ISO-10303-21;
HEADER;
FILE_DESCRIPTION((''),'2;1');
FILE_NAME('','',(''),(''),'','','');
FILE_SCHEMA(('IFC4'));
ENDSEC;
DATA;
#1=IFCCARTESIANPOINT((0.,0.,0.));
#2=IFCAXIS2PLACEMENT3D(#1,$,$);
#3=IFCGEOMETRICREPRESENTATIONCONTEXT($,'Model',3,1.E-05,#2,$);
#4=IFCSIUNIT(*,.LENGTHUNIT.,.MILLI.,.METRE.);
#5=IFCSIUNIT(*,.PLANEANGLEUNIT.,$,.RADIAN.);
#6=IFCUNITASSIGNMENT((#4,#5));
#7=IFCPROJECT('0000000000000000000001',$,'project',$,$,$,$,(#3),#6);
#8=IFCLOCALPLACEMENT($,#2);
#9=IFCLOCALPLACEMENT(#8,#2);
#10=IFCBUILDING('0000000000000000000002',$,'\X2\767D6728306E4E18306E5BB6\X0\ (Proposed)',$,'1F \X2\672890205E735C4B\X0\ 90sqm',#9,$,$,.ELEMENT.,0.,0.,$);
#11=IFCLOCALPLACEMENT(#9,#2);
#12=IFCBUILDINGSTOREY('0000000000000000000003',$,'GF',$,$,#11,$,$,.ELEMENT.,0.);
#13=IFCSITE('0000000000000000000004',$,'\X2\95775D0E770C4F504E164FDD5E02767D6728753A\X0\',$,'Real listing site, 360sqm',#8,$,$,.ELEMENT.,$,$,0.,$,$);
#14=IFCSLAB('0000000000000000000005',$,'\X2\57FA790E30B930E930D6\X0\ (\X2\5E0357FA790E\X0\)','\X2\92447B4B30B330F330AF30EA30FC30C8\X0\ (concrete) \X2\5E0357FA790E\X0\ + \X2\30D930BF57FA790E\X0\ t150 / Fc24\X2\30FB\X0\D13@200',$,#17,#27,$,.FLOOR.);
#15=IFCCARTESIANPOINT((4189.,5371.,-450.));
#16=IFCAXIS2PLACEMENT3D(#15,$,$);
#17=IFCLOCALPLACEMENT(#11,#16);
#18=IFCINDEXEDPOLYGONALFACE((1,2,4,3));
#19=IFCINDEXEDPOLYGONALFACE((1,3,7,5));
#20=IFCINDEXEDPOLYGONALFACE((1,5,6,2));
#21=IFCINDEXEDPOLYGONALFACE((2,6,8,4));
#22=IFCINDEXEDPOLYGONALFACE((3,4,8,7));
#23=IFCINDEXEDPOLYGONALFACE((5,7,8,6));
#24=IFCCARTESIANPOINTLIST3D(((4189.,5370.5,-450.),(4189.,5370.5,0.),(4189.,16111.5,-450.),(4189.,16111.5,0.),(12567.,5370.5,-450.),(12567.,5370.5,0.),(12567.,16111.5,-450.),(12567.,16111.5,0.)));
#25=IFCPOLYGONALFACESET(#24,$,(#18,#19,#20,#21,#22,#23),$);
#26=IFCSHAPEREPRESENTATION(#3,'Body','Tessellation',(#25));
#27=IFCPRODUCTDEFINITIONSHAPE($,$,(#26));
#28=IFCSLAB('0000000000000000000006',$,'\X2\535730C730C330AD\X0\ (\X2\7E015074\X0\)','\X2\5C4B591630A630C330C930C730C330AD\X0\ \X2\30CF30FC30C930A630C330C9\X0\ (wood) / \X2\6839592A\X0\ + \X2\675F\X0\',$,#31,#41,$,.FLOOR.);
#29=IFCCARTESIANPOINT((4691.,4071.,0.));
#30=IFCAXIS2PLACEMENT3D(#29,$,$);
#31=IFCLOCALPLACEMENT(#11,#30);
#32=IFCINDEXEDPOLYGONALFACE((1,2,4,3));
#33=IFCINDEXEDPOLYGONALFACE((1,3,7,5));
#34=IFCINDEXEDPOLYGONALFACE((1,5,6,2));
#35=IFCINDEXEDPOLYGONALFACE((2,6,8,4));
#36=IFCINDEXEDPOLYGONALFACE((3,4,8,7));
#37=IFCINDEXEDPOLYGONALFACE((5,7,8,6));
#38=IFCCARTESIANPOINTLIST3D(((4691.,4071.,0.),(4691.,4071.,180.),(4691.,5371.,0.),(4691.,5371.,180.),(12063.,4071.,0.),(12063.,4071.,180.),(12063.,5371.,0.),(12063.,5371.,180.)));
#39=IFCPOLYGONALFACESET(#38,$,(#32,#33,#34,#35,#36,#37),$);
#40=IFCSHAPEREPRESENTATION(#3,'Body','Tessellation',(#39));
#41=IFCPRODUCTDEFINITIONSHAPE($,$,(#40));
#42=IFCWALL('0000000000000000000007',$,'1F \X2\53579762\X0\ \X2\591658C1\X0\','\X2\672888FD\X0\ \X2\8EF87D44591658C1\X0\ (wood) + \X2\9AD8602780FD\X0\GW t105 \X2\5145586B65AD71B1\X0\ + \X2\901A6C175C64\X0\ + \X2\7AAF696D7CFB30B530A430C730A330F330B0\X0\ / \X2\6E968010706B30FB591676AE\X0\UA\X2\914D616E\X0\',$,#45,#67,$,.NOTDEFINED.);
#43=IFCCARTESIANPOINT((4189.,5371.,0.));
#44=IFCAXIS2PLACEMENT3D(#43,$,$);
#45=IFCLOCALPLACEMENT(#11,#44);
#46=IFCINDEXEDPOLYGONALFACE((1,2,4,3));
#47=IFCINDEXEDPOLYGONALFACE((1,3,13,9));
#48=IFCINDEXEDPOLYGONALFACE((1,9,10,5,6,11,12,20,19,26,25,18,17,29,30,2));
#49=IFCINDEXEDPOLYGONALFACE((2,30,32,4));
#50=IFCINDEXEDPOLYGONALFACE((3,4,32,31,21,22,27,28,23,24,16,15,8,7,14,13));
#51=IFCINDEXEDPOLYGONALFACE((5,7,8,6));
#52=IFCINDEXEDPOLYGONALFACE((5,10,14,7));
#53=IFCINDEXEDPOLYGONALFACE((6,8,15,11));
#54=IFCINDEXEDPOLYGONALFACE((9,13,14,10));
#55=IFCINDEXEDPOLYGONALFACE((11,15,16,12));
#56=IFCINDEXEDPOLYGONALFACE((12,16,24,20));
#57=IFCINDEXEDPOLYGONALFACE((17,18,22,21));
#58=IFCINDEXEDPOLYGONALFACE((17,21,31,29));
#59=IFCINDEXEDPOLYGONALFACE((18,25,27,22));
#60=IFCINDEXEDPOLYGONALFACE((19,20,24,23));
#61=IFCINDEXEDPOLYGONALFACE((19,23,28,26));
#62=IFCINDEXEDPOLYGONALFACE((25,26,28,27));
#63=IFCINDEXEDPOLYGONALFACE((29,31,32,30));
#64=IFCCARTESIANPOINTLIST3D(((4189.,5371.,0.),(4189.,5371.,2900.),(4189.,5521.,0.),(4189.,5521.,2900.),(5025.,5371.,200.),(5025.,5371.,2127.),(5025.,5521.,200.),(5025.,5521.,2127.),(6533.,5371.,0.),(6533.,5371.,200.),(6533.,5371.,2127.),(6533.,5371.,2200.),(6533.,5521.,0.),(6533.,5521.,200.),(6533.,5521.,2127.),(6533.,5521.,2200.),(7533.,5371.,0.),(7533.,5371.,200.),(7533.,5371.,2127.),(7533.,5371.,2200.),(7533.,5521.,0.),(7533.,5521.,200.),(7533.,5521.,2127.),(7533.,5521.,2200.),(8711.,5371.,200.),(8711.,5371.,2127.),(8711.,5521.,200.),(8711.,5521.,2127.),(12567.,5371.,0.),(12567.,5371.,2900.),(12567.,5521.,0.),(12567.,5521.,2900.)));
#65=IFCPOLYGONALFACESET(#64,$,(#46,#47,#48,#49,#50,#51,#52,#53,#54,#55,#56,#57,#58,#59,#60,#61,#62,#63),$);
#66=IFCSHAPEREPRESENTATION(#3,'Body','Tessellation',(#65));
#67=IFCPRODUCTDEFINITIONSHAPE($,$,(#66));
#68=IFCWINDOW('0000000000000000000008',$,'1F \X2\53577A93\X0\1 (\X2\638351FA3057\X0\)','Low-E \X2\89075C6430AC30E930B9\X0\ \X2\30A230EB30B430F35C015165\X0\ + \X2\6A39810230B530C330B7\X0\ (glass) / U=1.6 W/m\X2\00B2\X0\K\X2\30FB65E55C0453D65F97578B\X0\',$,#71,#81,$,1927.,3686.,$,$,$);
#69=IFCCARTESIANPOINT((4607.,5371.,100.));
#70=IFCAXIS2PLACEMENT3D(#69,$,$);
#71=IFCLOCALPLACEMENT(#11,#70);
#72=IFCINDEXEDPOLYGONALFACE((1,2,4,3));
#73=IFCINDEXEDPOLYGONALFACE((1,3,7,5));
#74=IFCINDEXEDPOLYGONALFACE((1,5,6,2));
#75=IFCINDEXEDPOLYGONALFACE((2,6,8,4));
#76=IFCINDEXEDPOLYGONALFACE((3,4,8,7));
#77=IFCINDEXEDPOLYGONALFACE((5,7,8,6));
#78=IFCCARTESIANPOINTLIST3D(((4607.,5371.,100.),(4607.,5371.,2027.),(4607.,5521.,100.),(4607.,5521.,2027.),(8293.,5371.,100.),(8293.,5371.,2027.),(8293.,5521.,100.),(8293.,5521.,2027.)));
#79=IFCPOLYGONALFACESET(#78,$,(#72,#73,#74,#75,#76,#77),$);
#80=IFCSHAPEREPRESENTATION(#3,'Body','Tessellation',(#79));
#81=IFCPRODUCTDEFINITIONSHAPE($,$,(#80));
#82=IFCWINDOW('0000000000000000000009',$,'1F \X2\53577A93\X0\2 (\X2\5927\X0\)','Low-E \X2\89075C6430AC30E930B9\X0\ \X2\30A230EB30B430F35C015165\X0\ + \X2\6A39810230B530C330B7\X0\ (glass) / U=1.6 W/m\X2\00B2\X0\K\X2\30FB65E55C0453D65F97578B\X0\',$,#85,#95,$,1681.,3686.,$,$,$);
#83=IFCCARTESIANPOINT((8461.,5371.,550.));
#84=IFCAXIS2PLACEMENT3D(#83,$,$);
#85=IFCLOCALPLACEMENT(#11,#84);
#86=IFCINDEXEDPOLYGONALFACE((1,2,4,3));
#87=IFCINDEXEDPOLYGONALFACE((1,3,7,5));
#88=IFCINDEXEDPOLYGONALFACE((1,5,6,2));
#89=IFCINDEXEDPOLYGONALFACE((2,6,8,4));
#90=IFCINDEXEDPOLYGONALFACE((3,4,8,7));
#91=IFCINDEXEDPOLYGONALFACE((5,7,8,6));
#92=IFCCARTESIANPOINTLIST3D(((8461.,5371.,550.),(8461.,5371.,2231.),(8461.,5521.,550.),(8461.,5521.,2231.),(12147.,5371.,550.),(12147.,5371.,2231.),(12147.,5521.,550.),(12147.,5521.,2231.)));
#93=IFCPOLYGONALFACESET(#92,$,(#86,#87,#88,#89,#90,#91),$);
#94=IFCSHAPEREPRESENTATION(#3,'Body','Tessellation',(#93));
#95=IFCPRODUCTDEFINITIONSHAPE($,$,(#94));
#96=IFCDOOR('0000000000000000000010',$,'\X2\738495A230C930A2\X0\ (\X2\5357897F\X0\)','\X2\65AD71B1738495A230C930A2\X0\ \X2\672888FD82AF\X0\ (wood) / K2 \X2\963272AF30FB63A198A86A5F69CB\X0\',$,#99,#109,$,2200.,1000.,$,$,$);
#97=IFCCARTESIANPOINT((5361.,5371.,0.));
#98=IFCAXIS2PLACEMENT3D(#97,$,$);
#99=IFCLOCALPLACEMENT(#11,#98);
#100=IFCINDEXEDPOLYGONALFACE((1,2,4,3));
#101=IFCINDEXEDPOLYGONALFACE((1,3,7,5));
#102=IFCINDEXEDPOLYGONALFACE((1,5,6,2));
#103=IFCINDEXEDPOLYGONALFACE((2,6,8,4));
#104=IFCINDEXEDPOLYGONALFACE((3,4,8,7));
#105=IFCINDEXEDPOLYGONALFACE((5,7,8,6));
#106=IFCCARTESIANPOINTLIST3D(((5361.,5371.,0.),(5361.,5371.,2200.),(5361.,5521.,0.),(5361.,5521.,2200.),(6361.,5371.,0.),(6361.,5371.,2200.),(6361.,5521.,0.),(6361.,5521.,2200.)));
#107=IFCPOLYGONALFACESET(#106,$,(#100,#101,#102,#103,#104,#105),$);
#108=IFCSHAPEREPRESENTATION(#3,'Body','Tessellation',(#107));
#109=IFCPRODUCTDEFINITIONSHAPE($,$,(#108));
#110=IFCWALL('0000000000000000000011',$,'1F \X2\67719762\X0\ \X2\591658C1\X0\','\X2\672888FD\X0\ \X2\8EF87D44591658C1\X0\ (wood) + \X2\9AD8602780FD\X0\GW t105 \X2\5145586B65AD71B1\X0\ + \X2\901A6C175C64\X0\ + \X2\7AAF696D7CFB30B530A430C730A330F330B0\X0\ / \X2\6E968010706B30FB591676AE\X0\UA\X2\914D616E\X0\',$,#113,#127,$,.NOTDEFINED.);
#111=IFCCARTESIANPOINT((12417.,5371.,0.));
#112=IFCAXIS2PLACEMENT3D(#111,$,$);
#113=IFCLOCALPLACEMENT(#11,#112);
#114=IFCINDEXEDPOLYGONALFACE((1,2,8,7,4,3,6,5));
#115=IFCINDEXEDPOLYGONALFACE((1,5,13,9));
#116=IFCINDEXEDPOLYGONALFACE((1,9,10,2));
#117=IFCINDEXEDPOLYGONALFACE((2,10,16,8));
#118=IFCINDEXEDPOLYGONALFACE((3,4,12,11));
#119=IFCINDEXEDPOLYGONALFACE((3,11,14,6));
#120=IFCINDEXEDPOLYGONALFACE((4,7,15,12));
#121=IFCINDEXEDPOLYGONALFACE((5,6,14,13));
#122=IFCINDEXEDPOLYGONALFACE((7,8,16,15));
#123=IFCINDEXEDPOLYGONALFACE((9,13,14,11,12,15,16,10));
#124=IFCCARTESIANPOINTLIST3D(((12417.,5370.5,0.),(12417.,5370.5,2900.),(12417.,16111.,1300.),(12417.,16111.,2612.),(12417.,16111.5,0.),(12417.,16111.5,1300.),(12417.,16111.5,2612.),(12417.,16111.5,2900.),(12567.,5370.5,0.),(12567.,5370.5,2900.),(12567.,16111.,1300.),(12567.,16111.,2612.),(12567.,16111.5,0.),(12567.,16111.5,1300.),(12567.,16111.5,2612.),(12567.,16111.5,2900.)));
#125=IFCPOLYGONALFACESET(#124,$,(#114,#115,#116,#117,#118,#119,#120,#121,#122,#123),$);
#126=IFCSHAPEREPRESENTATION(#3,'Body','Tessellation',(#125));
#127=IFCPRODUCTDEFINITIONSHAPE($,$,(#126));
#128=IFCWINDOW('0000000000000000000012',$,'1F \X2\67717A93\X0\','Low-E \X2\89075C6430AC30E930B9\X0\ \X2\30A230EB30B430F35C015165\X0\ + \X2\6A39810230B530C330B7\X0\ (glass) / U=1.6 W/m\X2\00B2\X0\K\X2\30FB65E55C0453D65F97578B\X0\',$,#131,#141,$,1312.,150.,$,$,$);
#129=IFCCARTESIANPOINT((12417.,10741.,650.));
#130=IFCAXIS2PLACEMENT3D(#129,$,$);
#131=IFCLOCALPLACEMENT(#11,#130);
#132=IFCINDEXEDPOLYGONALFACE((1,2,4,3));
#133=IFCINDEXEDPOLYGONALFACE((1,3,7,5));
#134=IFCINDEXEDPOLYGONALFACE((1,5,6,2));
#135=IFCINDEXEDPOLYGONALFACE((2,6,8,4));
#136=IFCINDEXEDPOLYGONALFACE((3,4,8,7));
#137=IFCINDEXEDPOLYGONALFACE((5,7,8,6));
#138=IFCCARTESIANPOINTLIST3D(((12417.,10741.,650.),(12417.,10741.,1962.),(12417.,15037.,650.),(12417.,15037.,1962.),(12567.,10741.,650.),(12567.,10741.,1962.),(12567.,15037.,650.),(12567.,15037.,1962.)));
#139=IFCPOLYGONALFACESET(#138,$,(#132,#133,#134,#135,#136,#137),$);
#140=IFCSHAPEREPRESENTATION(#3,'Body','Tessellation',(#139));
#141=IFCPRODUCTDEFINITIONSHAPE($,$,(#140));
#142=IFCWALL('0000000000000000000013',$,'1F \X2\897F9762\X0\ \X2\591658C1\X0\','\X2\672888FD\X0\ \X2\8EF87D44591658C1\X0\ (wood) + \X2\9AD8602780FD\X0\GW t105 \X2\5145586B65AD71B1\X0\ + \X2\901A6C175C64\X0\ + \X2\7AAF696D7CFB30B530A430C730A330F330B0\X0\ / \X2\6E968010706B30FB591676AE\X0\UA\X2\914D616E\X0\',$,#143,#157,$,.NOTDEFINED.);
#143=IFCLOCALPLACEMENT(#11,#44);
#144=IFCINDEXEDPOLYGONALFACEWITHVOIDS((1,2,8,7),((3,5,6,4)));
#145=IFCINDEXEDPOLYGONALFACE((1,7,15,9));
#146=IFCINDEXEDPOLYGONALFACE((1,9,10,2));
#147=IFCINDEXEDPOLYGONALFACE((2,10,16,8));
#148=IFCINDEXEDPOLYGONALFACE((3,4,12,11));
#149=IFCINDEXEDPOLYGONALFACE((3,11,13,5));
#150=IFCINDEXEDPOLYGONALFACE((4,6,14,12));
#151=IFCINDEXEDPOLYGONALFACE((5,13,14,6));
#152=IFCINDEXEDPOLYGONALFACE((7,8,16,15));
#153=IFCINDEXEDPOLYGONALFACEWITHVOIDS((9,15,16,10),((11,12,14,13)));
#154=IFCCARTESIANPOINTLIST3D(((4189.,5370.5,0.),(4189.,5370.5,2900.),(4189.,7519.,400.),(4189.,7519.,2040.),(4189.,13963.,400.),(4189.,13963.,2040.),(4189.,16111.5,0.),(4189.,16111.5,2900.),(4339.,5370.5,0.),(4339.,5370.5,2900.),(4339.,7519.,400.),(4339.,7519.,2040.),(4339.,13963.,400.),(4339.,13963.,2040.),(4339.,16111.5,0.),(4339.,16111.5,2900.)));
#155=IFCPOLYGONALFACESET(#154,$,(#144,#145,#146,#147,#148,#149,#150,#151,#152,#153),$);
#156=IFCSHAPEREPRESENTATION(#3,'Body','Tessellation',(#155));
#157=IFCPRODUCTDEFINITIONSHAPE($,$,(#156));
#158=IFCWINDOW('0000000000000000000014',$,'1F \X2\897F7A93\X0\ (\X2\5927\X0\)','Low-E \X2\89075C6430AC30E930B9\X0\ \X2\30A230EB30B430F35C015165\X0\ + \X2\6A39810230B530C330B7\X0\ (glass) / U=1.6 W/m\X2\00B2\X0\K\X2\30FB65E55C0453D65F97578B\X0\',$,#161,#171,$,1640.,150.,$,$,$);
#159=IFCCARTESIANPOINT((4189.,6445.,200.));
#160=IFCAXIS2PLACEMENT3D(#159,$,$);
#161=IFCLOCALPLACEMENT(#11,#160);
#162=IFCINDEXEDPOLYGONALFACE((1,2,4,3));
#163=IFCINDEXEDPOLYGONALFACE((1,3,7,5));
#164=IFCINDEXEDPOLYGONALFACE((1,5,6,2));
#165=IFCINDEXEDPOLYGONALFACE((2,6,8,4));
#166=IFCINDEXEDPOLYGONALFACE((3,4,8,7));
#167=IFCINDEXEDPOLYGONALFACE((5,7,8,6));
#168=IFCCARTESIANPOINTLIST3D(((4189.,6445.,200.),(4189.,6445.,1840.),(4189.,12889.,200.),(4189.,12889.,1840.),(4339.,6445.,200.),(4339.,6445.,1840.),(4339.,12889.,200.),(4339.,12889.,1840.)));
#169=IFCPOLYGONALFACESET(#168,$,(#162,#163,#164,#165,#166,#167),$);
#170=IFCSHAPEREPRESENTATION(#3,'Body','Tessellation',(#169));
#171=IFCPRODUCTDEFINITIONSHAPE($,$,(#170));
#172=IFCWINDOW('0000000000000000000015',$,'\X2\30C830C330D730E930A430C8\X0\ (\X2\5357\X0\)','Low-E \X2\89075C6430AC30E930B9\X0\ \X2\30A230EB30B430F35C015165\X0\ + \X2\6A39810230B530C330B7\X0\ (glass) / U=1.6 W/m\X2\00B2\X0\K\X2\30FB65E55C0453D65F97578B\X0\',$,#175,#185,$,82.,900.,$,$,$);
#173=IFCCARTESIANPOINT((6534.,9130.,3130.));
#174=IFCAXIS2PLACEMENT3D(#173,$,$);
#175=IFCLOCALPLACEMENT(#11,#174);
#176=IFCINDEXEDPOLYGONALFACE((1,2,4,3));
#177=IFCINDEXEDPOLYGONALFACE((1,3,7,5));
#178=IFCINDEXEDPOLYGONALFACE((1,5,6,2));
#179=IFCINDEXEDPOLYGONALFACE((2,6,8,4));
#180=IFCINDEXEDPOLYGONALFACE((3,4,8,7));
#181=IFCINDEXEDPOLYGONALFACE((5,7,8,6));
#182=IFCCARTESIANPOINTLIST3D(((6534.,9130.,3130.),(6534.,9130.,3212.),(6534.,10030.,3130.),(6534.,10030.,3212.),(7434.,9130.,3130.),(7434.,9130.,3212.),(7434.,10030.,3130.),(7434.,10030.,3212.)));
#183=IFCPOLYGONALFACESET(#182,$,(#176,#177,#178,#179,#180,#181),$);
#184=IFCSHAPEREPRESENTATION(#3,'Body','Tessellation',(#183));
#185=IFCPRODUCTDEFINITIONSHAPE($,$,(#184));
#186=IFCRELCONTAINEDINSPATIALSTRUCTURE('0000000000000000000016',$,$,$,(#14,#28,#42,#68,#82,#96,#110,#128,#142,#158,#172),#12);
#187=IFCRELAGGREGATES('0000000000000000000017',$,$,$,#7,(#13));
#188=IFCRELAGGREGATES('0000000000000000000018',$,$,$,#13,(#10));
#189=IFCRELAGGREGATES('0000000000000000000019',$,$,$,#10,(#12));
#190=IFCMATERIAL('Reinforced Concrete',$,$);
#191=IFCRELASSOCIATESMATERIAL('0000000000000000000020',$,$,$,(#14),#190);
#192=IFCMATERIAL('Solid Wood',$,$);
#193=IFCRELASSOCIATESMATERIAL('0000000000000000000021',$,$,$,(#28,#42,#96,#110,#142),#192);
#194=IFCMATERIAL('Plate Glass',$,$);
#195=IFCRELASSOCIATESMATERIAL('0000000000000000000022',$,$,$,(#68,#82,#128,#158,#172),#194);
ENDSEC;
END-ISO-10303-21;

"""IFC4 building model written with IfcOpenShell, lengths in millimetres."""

from ifc_helpers import new_model, si_unit, frame, frame_2d, origin, place, context, project, spatial, rectangle, extrude, material, element, fill, save


model = new_model("IFC4")

# Units and contexts
model_context = context("Model", 3, precision=1e-05, world=origin())
ifc_project = project(units=[si_unit("LENGTHUNIT", "METRE", prefix="MILLI"), si_unit("PLANEANGLEUNIT", "RADIAN")], contexts=[model_context])

# Site, building, storey
site_placement = place(None, origin())
site = spatial("IfcSite", under=ifc_project, at=site_placement, Name="長崎県佐世保市白木町", ObjectType="Real listing site, 360sqm", CompositionType="ELEMENT", RefElevation=0.0)
building_placement = place(site_placement, origin())
building = spatial("IfcBuilding", under=site, at=building_placement, Name="白木の丘の家 (Proposed)", ObjectType="1F 木造平屋 90sqm", CompositionType="ELEMENT", ElevationOfRefHeight=0.0, ElevationOfTerrain=0.0)
storey_placement = place(building_placement, origin())
storey = spatial("IfcBuildingStorey", under=building, at=storey_placement, Name="GF", CompositionType="ELEMENT", Elevation=0.0)

# Slabs
ifc_material_1 = material(Name="Reinforced Concrete")
slab_1_placement = place(storey_placement, frame((4189.0, 5371.0, -450.0)))
element("IfcSlab", 1, at=slab_1_placement, inside=storey, material=ifc_material_1, Name="基礎スラブ (布基礎)", Description="鉄筋コンクリート (concrete) 布基礎 + ベタ基礎 t150 / Fc24・D13@200", PredefinedType="FLOOR", context=model_context, shape_type="SweptSolid", body=[
    extrude(rectangle(XDim=8378.0, YDim=10741.0, at=frame_2d((4189.0, 5370.0))), frame((4189.0, 5371.0, -450.0)), (0.0, 0.0, 1.0), 450.0),
])
ifc_material_2 = material(Name="Solid Wood")
slab_2_placement = place(storey_placement, frame((4691.0, 4071.0, 0.0)))
element("IfcSlab", 2, at=slab_2_placement, inside=storey, material=ifc_material_2, Name="南デッキ (縁側)", Description="屋外ウッドデッキ ハードウッド (wood) / 根太 + 束", PredefinedType="FLOOR", context=model_context, shape_type="SweptSolid", body=[
    extrude(rectangle(XDim=7372.0, YDim=1300.0, at=frame_2d((3686.0, 650.0))), frame((4691.0, 4071.0, 0.0)), (0.0, 0.0, 1.0), 180.0),
])

# Wall, openings, windows, door
wall_1_placement = place(storey_placement, frame((4189.0, 5371.0, 0.0)))
wall_1 = element("IfcWall", 3, at=wall_1_placement, inside=storey, material=ifc_material_2, Name="1F 南面 外壁", Description="木製 軸組外壁 (wood) + 高性能GW t105 充填断熱 + 通気層 + 窯業系サイディング / 準耐火・外皮UA配慮", PredefinedType="NOTDEFINED", context=model_context, shape_type="SweptSolid", body=[
    extrude(rectangle(XDim=8378.0, YDim=150.0, at=frame_2d((4189.0, 75.0))), frame((4189.0, 5371.0, 0.0)), (0.0, 0.0, 1.0), 2900.0),
])
opening_1_placement = place(storey_placement, frame((4607.0, 5371.0, 100.0)))
opening_1 = element("IfcOpeningElement", 4, at=opening_1_placement, cuts=wall_1, PredefinedType="NOTDEFINED", context=model_context, shape_type="SweptSolid", body=[
    extrude(rectangle(XDim=3686.0, YDim=150.0, at=frame_2d((1843.0, 75.0))), frame((4607.0, 5371.0, 100.0)), (0.0, 0.0, 1.0), 1927.0),
])
opening_2_placement = place(storey_placement, frame((8461.0, 5371.0, 550.0)))
opening_2 = element("IfcOpeningElement", 5, at=opening_2_placement, cuts=wall_1, PredefinedType="NOTDEFINED", context=model_context, shape_type="SweptSolid", body=[
    extrude(rectangle(XDim=3686.0, YDim=150.0, at=frame_2d((1843.0, 75.0))), frame((8461.0, 5371.0, 550.0)), (0.0, 0.0, 1.0), 1681.0),
])
opening_3_placement = place(storey_placement, frame((5361.0, 5371.0, 0.0)))
opening_3 = element("IfcOpeningElement", 6, at=opening_3_placement, cuts=wall_1, PredefinedType="NOTDEFINED", context=model_context, shape_type="SweptSolid", body=[
    extrude(rectangle(XDim=1000.0, YDim=150.0, at=frame_2d((500.0, 75.0))), frame((5361.0, 5371.0, 0.0)), (0.0, 0.0, 1.0), 2200.0),
])
ifc_material_3 = material(Name="Plate Glass")
window_1_placement = place(storey_placement, frame((4607.0, 5371.0, 100.0)))
window_1 = element("IfcWindow", 7, at=window_1_placement, inside=storey, material=ifc_material_3, Name="1F 南窓1 (掃出し)", Description="Low-E 複層ガラス アルゴン封入 + 樹脂サッシ (glass) / U=1.6 W/m²K・日射取得型", OverallHeight=1927.0, OverallWidth=3686.0, context=model_context, shape_type="SweptSolid", body=[
    extrude(rectangle(XDim=3686.0, YDim=150.0, at=frame_2d((1843.0, 75.0))), frame((4607.0, 5371.0, 100.0)), (0.0, 0.0, 1.0), 1927.0),
])
fill(opening_1, window_1)
window_2_placement = place(storey_placement, frame((8461.0, 5371.0, 550.0)))
window_2 = element("IfcWindow", 8, at=window_2_placement, inside=storey, material=ifc_material_3, Name="1F 南窓2 (大)", Description="Low-E 複層ガラス アルゴン封入 + 樹脂サッシ (glass) / U=1.6 W/m²K・日射取得型", OverallHeight=1681.0, OverallWidth=3686.0, context=model_context, shape_type="SweptSolid", body=[
    extrude(rectangle(XDim=3686.0, YDim=150.0, at=frame_2d((1843.0, 75.0))), frame((8461.0, 5371.0, 550.0)), (0.0, 0.0, 1.0), 1681.0),
])
fill(opening_2, window_2)
door_placement = place(storey_placement, frame((5361.0, 5371.0, 0.0)))
door = element("IfcDoor", 9, at=door_placement, inside=storey, material=ifc_material_2, Name="玄関ドア (南西)", Description="断熱玄関ドア 木製芯 (wood) / K2 防犯・採風機構", OverallHeight=2200.0, OverallWidth=1000.0, context=model_context, shape_type="SweptSolid", body=[
    extrude(rectangle(XDim=1000.0, YDim=150.0, at=frame_2d((500.0, 75.0))), frame((5361.0, 5371.0, 0.0)), (0.0, 0.0, 1.0), 2200.0),
])
fill(opening_3, door)

# Walls, openings, windows
wall_2_placement = place(storey_placement, frame((12417.0, 5371.0, 0.0)))
wall_2 = element("IfcWall", 10, at=wall_2_placement, inside=storey, material=ifc_material_2, Name="1F 東面 外壁", Description="木製 軸組外壁 (wood) + 高性能GW t105 充填断熱 + 通気層 + 窯業系サイディング / 準耐火・外皮UA配慮", PredefinedType="NOTDEFINED", context=model_context, shape_type="SweptSolid", body=[
    extrude(rectangle(XDim=150.0, YDim=10741.0, at=frame_2d((75.0, 5370.0))), frame((12417.0, 5371.0, 0.0)), (0.0, 0.0, 1.0), 2900.0),
])
opening_4_placement = place(storey_placement, frame((12417.0, 10741.0, 650.0)))
opening_4 = element("IfcOpeningElement", 11, at=opening_4_placement, cuts=wall_2, PredefinedType="NOTDEFINED", context=model_context, shape_type="SweptSolid", body=[
    extrude(rectangle(XDim=150.0, YDim=4296.0, at=frame_2d((75.0, 2148.0))), frame((12417.0, 10741.0, 650.0)), (0.0, 0.0, 1.0), 1312.0),
])
window_3_placement = place(storey_placement, frame((12417.0, 10741.0, 650.0)))
window_3 = element("IfcWindow", 12, at=window_3_placement, inside=storey, material=ifc_material_3, Name="1F 東窓", Description="Low-E 複層ガラス アルゴン封入 + 樹脂サッシ (glass) / U=1.6 W/m²K・日射取得型", OverallHeight=1312.0, OverallWidth=150.0, context=model_context, shape_type="SweptSolid", body=[
    extrude(rectangle(XDim=150.0, YDim=4296.0, at=frame_2d((75.0, 2148.0))), frame((12417.0, 10741.0, 650.0)), (0.0, 0.0, 1.0), 1312.0),
])
fill(opening_4, window_3)
wall_3_placement = place(storey_placement, frame((4189.0, 5371.0, 0.0)))
wall_3 = element("IfcWall", 13, at=wall_3_placement, inside=storey, material=ifc_material_2, Name="1F 西面 外壁", Description="木製 軸組外壁 (wood) + 高性能GW t105 充填断熱 + 通気層 + 窯業系サイディング / 準耐火・外皮UA配慮", PredefinedType="NOTDEFINED", context=model_context, shape_type="SweptSolid", body=[
    extrude(rectangle(XDim=150.0, YDim=10741.0, at=frame_2d((75.0, 5370.0))), frame((4189.0, 5371.0, 0.0)), (0.0, 0.0, 1.0), 2900.0),
])
opening_5_placement = place(storey_placement, frame((4189.0, 6445.0, 200.0)))
opening_5 = element("IfcOpeningElement", 14, at=opening_5_placement, cuts=wall_3, PredefinedType="NOTDEFINED", context=model_context, shape_type="SweptSolid", body=[
    extrude(rectangle(XDim=150.0, YDim=6444.0, at=frame_2d((75.0, 3222.0))), frame((4189.0, 6445.0, 200.0)), (0.0, 0.0, 1.0), 1640.0),
])
window_4_placement = place(storey_placement, frame((4189.0, 6445.0, 200.0)))
window_4 = element("IfcWindow", 15, at=window_4_placement, inside=storey, material=ifc_material_3, Name="1F 西窓 (大)", Description="Low-E 複層ガラス アルゴン封入 + 樹脂サッシ (glass) / U=1.6 W/m²K・日射取得型", OverallHeight=1640.0, OverallWidth=150.0, context=model_context, shape_type="SweptSolid", body=[
    extrude(rectangle(XDim=150.0, YDim=6444.0, at=frame_2d((75.0, 3222.0))), frame((4189.0, 6445.0, 200.0)), (0.0, 0.0, 1.0), 1640.0),
])
fill(opening_5, window_4)

# Window
window_5_placement = place(storey_placement, frame((6534.0, 9130.0, 3130.0)))
element("IfcWindow", 16, at=window_5_placement, inside=storey, material=ifc_material_3, Name="トップライト (南)", Description="Low-E 複層ガラス アルゴン封入 + 樹脂サッシ (glass) / U=1.6 W/m²K・日射取得型", OverallHeight=82.0, OverallWidth=900.0, context=model_context, shape_type="SweptSolid", body=[
    extrude(rectangle(XDim=900.0, YDim=900.0, at=frame_2d((450.0, 450.0))), frame((6534.0, 9130.0, 3130.0)), (0.0, 0.0, 1.0), 82.0),
])

save(model, "model.ifc")
